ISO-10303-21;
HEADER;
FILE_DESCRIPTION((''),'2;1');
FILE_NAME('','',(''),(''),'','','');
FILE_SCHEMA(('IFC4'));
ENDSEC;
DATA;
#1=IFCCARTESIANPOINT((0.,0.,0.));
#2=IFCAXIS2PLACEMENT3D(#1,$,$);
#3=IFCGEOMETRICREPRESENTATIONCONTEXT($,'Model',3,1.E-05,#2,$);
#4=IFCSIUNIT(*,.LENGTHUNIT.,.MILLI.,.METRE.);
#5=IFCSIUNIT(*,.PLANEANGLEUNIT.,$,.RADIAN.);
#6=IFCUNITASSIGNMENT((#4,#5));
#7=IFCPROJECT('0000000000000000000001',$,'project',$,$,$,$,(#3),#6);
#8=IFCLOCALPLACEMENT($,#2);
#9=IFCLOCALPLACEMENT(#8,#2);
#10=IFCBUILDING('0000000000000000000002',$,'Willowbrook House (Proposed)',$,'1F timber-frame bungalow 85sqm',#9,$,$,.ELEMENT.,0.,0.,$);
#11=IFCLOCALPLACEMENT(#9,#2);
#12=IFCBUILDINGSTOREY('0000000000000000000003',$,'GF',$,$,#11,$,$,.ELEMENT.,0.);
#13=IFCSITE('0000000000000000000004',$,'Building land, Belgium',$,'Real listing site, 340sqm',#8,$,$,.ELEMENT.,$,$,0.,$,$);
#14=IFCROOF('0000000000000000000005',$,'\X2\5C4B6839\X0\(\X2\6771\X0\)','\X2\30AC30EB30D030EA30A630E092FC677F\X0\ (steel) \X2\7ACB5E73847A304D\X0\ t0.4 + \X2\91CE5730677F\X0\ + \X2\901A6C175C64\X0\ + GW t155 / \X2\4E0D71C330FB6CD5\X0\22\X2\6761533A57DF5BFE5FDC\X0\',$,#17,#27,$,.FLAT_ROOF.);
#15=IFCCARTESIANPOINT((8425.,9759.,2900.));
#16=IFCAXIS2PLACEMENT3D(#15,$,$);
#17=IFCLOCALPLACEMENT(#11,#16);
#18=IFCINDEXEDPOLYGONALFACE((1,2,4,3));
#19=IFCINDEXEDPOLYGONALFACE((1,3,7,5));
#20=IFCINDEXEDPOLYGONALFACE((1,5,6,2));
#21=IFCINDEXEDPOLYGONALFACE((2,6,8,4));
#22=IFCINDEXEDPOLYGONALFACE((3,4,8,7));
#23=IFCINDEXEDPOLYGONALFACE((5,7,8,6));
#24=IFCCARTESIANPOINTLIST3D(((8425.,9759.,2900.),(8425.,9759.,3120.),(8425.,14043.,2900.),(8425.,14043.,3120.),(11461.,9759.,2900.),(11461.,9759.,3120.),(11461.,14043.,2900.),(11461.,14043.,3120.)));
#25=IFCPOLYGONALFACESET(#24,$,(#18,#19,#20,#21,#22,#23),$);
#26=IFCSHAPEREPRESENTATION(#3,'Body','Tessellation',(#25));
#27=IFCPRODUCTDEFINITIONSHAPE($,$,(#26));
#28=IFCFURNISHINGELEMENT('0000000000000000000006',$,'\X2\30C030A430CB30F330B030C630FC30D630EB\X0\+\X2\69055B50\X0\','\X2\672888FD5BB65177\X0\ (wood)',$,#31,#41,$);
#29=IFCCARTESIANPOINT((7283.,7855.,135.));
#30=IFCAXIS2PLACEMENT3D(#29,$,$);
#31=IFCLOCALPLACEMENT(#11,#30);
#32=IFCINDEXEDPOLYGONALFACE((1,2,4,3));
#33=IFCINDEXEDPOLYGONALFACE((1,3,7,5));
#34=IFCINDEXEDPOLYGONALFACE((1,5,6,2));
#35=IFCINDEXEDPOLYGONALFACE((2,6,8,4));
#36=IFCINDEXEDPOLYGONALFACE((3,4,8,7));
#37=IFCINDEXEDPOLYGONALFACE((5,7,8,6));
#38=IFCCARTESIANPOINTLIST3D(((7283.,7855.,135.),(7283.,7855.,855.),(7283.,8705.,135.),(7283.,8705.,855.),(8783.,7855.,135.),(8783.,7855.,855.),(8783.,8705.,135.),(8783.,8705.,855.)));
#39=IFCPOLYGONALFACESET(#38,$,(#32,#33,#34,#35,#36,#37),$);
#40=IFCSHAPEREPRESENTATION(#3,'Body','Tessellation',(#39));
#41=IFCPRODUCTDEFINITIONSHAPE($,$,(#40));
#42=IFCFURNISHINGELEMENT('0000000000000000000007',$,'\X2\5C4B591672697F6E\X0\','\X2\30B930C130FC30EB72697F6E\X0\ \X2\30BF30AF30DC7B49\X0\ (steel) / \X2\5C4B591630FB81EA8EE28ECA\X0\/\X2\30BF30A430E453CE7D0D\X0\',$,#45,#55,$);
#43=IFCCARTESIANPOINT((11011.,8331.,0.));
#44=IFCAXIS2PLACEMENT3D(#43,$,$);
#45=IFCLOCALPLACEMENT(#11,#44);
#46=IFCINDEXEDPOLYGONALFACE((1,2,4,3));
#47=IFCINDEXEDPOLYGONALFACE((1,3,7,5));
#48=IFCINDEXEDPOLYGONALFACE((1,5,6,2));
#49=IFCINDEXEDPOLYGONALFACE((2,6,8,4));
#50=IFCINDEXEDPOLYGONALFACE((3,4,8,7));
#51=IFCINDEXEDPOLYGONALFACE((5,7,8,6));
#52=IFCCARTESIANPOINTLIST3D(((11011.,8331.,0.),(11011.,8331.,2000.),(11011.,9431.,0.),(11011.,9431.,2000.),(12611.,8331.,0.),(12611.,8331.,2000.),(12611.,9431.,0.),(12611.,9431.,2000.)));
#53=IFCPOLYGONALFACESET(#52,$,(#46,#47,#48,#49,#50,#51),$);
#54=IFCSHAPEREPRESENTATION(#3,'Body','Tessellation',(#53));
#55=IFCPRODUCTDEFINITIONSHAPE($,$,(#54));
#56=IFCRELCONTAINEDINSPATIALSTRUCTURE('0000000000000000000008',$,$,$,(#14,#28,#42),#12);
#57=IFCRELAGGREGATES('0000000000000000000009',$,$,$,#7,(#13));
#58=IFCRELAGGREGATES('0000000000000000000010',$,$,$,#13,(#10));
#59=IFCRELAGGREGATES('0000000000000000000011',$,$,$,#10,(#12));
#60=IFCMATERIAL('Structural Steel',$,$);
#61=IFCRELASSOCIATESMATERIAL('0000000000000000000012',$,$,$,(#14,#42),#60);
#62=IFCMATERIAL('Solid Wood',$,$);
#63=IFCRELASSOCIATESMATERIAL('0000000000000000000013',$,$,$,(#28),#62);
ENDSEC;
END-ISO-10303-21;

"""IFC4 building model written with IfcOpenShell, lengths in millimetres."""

from ifc_helpers import new_model, si_unit, frame, frame_2d, origin, place, context, project, spatial, rectangle, extrude, material, element, save


model = new_model("IFC4")

# Units and contexts
model_context = context("Model", 3, precision=1e-05, world=origin())
ifc_project = project(units=[si_unit("LENGTHUNIT", "METRE", prefix="MILLI"), si_unit("PLANEANGLEUNIT", "RADIAN")], contexts=[model_context])

# Site, building, storey
site_placement = place(None, origin())
site = spatial("IfcSite", under=ifc_project, at=site_placement, Name="Building land, Belgium", ObjectType="Real listing site, 340sqm", CompositionType="ELEMENT", RefElevation=0.0)
building_placement = place(site_placement, origin())
building = spatial("IfcBuilding", under=site, at=building_placement, Name="Willowbrook House (Proposed)", ObjectType="1F timber-frame bungalow 85sqm", CompositionType="ELEMENT", ElevationOfRefHeight=0.0, ElevationOfTerrain=0.0)
storey_placement = place(building_placement, origin())
storey = spatial("IfcBuildingStorey", under=building, at=storey_placement, Name="GF", CompositionType="ELEMENT", Elevation=0.0)

# Shared definitions
ifc_material_1 = material(Name="Solid Wood")

# Roof
ifc_material_2 = material(Name="Structural Steel")
roof_1_placement = place(storey_placement, frame((8425.0, 9759.0, 2900.0)))
element("IfcRoof", 1, at=roof_1_placement, inside=storey, material=ifc_material_2, Name="屋根(東)", Description="ガルバリウム鋼板 (steel) 立平葺き t0.4 + 野地板 + 通気層 + GW t155 / 不燃・法22条区域対応", PredefinedType="FLAT_ROOF", context=model_context, shape_type="SweptSolid", body=[
    extrude(rectangle(XDim=3036.0, YDim=4284.0, at=frame_2d((1518.0, 2142.0))), frame((8425.0, 9759.0, 2900.0)), (0.0, 0.0, 1.0), 220.0),
])

# Furnishing elements
furnishing_1_placement = place(storey_placement, frame((7283.0, 7855.0, 135.0)))
element("IfcFurnishingElement", 2, at=furnishing_1_placement, inside=storey, material=ifc_material_1, Name="ダイニングテーブル+椅子", Description="木製家具 (wood)", context=model_context, shape_type="SweptSolid", body=[
    extrude(rectangle(XDim=1500.0, YDim=850.0, at=frame_2d((750.0, 425.0))), frame((7283.0, 7855.0, 135.0)), (0.0, 0.0, 1.0), 720.0),
])
furnishing_2_placement = place(storey_placement, frame((11011.0, 8331.0, 0.0)))
element("IfcFurnishingElement", 3, at=furnishing_2_placement, inside=storey, material=ifc_material_2, Name="屋外物置", Description="スチール物置 タクボ等 (steel) / 屋外・自転車/タイヤ収納", context=model_context, shape_type="SweptSolid", body=[
    extrude(rectangle(XDim=1600.0, YDim=1100.0, at=frame_2d((800.0, 550.0))), frame((11011.0, 8331.0, 0.0)), (0.0, 0.0, 1.0), 2000.0),
])

save(model, "model.ifc")
